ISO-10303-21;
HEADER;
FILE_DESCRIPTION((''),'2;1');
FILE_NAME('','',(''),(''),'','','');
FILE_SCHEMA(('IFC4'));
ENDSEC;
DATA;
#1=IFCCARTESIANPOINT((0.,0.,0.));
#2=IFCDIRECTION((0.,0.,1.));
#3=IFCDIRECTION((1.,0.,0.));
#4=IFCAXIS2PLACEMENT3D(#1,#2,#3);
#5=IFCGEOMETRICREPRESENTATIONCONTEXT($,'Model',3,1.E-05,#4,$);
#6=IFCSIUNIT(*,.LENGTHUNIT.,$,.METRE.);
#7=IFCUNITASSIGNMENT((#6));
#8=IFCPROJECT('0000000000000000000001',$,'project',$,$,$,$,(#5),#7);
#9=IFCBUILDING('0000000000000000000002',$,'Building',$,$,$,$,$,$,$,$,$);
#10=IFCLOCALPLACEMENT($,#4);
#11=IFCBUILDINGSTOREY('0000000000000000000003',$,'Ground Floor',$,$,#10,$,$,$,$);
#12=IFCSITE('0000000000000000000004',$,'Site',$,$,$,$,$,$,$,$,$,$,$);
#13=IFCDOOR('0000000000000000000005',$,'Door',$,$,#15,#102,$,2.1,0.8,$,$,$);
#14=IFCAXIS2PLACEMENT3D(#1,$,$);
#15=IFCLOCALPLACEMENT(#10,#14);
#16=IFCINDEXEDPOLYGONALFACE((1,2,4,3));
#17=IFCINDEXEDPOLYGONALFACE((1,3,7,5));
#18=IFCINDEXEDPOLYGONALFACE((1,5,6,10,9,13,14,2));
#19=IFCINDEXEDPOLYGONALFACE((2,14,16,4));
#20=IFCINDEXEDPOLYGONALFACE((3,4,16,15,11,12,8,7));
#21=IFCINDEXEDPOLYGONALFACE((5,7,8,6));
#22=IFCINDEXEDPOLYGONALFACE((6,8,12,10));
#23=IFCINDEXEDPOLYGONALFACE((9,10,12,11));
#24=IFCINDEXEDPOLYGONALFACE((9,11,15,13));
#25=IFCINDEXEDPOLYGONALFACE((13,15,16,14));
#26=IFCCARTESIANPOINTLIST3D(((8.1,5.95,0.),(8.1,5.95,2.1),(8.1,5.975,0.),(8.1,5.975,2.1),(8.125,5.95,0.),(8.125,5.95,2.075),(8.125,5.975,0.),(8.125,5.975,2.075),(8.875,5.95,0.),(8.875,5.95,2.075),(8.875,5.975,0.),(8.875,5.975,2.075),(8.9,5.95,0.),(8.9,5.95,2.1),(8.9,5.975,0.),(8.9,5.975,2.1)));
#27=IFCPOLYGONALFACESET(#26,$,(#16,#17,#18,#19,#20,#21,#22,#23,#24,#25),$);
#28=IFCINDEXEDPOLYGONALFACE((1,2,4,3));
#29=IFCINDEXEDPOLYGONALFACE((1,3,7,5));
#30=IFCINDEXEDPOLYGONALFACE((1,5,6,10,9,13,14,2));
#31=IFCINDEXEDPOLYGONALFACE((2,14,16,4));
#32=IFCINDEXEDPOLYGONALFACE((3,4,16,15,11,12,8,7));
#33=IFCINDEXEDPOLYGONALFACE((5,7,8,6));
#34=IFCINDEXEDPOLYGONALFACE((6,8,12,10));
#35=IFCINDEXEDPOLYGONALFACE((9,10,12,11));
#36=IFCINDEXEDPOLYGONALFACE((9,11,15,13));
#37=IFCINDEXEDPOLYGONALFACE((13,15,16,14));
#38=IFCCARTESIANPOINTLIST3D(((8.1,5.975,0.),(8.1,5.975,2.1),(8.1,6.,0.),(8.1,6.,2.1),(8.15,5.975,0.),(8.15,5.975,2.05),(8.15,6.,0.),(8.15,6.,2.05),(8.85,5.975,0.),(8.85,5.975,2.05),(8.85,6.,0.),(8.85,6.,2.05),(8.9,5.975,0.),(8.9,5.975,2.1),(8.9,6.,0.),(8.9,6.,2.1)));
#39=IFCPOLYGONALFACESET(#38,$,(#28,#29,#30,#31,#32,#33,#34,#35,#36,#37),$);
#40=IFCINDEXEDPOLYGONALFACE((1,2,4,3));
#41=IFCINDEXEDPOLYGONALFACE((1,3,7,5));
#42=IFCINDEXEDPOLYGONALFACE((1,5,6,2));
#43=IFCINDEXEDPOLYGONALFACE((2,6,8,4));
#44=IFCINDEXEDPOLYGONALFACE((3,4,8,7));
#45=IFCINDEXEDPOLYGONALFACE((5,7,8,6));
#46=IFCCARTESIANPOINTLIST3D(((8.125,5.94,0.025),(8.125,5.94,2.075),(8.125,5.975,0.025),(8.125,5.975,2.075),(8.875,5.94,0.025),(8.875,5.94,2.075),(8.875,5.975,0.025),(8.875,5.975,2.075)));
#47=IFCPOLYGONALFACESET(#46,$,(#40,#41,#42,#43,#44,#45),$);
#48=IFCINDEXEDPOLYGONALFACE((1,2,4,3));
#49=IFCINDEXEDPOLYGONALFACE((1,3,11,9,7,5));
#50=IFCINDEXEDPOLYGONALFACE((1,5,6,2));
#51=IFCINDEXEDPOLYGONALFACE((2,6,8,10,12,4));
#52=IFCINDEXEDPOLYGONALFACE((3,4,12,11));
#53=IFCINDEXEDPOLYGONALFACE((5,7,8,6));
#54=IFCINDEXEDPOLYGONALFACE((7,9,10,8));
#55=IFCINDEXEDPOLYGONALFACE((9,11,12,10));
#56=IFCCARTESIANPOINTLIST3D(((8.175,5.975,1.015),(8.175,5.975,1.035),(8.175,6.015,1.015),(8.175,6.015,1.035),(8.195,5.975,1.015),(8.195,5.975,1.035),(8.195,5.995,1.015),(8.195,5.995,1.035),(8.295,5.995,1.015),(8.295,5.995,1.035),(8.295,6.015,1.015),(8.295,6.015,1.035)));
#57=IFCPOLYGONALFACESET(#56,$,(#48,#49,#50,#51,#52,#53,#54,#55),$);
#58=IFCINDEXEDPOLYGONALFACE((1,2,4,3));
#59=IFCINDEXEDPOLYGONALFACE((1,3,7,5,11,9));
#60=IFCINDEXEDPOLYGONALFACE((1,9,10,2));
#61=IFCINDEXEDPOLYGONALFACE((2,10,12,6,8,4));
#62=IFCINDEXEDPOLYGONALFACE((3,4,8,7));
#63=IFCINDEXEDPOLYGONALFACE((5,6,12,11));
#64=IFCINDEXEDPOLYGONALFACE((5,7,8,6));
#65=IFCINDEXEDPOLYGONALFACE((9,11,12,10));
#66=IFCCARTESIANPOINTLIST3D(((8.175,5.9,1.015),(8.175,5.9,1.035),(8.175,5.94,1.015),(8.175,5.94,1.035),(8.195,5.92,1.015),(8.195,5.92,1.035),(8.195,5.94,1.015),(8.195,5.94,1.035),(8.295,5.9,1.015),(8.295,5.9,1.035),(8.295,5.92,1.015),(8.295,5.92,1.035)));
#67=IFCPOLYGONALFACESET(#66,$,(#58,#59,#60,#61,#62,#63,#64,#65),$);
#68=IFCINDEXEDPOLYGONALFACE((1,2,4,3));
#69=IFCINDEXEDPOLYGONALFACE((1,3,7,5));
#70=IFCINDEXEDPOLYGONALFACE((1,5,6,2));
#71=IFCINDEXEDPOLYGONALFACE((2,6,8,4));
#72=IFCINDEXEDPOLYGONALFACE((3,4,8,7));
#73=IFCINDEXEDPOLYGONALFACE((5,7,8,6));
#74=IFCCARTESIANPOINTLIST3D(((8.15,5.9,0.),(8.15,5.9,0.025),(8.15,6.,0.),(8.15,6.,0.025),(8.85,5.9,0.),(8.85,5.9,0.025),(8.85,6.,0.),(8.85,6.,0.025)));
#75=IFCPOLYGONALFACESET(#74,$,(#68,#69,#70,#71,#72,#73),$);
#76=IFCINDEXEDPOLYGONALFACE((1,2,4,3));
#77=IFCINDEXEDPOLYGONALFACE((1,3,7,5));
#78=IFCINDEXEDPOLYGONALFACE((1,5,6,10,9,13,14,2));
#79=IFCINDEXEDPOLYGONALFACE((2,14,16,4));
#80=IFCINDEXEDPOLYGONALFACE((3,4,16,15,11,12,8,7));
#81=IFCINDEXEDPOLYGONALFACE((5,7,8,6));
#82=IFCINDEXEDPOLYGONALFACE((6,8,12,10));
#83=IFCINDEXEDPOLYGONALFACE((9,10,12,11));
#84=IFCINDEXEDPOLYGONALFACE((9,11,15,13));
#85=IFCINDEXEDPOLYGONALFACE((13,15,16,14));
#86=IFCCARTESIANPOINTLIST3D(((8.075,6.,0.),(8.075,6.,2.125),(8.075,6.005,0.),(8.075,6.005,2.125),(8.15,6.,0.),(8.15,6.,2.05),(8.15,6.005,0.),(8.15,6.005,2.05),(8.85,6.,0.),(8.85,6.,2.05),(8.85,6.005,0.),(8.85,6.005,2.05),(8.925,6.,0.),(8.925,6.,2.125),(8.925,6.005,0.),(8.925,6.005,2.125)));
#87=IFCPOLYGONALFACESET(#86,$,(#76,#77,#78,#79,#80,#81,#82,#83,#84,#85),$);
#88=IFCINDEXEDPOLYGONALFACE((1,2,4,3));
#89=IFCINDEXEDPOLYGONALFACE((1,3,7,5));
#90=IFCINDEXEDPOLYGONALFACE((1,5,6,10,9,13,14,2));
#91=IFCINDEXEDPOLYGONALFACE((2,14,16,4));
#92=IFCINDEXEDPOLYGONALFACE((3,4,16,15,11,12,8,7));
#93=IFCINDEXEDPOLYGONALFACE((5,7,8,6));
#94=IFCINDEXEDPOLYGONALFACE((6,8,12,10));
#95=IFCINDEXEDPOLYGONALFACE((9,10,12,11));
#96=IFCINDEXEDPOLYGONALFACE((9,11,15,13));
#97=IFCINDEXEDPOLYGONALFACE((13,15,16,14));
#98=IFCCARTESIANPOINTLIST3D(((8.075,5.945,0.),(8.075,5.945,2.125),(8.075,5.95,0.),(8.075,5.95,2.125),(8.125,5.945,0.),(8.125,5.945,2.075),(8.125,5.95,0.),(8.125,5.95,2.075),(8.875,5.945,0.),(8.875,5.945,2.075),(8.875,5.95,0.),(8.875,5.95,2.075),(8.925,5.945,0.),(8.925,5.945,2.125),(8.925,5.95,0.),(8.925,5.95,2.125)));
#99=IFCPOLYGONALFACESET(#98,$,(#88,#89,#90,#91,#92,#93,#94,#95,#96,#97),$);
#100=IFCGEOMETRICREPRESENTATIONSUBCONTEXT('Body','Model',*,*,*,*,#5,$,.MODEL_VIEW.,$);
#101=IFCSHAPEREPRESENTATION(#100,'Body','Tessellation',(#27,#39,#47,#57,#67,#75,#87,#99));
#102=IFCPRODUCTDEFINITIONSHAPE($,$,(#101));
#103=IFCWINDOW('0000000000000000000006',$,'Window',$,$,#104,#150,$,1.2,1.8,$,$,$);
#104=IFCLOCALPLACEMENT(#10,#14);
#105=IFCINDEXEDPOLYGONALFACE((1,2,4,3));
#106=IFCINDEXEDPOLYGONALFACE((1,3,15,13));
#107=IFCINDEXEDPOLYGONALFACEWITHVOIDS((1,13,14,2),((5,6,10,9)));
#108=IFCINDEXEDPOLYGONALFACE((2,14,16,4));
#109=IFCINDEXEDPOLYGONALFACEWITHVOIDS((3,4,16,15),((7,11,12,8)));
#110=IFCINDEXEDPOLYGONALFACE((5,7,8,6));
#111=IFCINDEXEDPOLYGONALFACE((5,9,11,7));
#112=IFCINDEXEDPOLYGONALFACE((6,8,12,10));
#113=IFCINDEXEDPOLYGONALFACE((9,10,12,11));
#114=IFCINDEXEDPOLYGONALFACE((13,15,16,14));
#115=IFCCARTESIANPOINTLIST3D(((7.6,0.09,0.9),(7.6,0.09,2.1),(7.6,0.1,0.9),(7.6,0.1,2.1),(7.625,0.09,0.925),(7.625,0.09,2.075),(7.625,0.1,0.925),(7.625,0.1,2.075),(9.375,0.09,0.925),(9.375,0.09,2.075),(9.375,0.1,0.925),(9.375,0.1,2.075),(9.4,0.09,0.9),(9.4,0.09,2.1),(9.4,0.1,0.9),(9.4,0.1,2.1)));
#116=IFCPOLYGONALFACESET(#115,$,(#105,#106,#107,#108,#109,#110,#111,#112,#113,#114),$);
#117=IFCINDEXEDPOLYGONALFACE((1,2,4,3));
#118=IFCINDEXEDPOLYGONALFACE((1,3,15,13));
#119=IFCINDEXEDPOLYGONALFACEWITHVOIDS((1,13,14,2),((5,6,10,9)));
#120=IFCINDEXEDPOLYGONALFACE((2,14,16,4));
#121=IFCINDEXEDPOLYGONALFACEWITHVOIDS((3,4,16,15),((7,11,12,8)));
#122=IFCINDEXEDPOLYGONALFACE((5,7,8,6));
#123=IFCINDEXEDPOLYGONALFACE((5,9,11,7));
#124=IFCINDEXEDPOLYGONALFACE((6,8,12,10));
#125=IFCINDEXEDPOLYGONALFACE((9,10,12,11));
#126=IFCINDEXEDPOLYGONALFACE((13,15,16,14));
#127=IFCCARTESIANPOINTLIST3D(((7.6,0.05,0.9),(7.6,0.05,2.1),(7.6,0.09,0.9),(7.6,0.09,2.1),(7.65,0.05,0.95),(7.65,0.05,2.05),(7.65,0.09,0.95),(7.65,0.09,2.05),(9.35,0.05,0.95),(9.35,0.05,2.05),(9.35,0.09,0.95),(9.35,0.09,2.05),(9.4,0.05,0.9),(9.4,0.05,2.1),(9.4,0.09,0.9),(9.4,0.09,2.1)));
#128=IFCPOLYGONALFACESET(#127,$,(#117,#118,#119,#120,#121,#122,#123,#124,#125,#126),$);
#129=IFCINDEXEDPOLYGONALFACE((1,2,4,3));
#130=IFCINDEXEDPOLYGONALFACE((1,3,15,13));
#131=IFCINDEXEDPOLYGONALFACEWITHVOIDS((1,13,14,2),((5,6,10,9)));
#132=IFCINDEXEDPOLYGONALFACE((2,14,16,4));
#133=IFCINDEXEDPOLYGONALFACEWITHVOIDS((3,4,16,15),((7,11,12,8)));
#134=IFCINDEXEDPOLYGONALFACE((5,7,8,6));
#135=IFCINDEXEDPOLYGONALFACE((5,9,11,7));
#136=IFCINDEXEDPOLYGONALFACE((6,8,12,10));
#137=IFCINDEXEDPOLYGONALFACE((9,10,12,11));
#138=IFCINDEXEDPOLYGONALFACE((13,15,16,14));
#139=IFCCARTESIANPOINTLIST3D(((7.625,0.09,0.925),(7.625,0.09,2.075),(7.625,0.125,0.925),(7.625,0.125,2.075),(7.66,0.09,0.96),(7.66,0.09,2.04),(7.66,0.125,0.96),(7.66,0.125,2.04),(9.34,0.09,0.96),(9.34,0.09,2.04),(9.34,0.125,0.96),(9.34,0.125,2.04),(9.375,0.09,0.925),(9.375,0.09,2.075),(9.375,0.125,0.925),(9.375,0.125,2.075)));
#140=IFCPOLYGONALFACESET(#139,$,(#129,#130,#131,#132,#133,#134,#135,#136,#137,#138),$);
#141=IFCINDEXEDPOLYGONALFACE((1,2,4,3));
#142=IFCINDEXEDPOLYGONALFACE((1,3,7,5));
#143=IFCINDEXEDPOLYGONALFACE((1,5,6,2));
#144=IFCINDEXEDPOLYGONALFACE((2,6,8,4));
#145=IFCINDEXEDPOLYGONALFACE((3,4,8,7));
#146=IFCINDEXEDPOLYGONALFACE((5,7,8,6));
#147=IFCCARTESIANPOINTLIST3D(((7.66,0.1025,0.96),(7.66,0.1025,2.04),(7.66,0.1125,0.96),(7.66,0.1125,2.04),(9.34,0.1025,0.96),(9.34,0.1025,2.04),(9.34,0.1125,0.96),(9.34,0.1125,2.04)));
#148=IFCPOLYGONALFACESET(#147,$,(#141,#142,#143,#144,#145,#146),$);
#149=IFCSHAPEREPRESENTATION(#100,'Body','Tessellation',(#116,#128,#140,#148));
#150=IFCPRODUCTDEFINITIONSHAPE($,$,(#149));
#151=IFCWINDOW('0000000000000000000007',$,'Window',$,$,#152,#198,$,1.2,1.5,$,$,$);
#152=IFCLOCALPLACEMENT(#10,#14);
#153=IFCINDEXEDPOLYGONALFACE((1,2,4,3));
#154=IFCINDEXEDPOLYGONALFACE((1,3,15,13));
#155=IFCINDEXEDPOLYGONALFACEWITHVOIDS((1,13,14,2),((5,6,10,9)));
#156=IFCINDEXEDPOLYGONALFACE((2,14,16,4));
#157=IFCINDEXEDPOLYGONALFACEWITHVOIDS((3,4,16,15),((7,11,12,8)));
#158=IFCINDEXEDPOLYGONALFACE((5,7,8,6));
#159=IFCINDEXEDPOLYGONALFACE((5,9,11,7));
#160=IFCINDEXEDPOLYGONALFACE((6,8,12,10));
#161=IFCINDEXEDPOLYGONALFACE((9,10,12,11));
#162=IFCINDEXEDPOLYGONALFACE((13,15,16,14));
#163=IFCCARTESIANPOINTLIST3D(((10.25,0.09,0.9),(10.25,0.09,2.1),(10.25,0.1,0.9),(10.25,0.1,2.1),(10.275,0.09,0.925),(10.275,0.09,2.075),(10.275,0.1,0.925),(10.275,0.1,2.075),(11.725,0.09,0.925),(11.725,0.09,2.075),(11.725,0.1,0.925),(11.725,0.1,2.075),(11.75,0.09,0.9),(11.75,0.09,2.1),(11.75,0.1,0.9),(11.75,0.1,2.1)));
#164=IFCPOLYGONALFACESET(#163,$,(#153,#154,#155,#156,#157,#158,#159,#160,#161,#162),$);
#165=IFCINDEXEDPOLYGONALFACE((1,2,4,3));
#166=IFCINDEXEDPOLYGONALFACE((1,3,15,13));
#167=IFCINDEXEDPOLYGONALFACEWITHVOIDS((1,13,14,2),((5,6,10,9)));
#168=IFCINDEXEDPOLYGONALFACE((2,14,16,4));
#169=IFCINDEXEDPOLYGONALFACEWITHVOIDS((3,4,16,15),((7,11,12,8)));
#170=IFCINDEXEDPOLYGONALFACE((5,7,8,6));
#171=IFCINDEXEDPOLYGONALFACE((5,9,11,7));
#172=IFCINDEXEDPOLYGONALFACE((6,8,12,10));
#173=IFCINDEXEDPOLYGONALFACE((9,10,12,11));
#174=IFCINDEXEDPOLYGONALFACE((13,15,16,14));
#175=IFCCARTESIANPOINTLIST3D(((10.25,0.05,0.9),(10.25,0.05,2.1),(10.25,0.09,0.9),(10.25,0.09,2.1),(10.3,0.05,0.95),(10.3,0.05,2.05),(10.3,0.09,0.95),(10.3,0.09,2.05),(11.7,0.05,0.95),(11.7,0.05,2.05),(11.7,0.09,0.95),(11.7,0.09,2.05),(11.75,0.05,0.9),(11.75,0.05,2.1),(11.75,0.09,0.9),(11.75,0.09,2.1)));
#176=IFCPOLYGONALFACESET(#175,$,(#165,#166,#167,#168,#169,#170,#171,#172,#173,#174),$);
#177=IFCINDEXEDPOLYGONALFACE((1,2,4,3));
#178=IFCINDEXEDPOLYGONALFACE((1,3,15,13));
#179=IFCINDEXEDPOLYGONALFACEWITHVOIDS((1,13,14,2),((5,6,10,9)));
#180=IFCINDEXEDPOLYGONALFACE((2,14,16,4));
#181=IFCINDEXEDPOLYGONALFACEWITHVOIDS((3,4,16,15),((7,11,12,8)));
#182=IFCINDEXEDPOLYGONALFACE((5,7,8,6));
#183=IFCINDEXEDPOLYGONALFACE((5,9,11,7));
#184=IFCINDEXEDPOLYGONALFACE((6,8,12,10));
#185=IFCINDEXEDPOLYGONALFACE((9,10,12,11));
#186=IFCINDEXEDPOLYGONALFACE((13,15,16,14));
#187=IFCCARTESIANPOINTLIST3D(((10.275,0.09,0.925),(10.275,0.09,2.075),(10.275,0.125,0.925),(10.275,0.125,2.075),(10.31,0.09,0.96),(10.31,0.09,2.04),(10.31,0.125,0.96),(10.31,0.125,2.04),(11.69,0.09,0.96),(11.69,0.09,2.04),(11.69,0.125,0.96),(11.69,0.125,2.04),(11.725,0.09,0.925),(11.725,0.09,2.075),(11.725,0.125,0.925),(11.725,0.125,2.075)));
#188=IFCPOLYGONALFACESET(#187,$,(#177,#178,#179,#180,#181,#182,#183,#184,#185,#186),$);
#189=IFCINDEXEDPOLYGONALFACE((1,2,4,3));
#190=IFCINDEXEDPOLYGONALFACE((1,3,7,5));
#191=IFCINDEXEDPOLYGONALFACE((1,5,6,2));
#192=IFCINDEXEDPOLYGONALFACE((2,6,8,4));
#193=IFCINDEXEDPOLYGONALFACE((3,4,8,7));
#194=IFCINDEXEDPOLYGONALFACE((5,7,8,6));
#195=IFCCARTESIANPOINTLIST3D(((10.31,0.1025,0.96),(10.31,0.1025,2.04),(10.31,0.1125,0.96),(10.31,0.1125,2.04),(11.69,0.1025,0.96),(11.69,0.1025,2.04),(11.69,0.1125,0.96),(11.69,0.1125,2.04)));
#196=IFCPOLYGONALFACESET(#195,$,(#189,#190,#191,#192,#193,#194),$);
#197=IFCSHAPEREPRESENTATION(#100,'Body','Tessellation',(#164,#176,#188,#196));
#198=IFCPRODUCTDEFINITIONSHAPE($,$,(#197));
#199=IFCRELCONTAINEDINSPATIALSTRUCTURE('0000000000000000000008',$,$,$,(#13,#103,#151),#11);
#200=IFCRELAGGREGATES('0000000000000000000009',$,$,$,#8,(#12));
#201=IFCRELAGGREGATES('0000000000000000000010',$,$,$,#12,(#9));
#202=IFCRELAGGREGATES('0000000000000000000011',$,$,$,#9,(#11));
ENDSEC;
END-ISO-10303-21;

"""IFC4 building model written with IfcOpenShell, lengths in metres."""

from ifc_helpers import new_model, si_unit, frame, origin_with_axes, place, context, subcontext, project, spatial, line, indexed_curve, outline, extrude, element, save


model = new_model("IFC4")

# Units and contexts
model_context = context("Model", 3, precision=1e-05, world=origin_with_axes())
body_context = subcontext(model_context, "Body", "Model", "MODEL_VIEW")
ifc_project = project(units=[si_unit("LENGTHUNIT", "METRE")], contexts=[model_context])

# Site, building, storey
site = spatial("IfcSite", under=ifc_project, Name="Site")
building = spatial("IfcBuilding", under=site, Name="Building")
storey_placement = place(None, origin_with_axes())
storey = spatial("IfcBuildingStorey", under=building, at=storey_placement, Name="Ground Floor")

# Door
door_1_placement = place(storey_placement, frame((8.9, 6.0, 0.0), z_axis=(0.0, 0.0, 1.0), x_axis=(-1.0, 0.0, 0.0)))
element("IfcDoor", 1, at=door_1_placement, inside=storey, Name="Door", OverallHeight=2.1, OverallWidth=0.8, context=body_context, shape_type="SweptSolid", body=[
    extrude(outline(indexed_curve([(0.0, 0.0), (0.0, 2.1), (0.8, 2.1), (0.8, 0.0), (0.775, 0.0), (0.775, 2.075), (0.025, 2.075), (0.025, 0.0)], segments=[line(1, 2, 3, 4, 5, 6, 7, 8, 1)])), frame((0.0, 0.025, 0.0), z_axis=(0.0, -1.0, 0.0), x_axis=(1.0, 0.0, 0.0)), (0.0, 0.0, -1.0), 0.025),
    extrude(outline(indexed_curve([(0.0, 0.0), (0.0, 2.1), (0.8, 2.1), (0.8, 0.0), (0.75, 0.0), (0.75, 2.05), (0.05, 2.05), (0.05, 0.0)], segments=[line(1, 2, 3, 4, 5, 6, 7, 8, 1)])), frame((0.0, 0.0, 0.0), z_axis=(0.0, -1.0, 0.0), x_axis=(1.0, 0.0, 0.0)), (0.0, 0.0, -1.0), 0.025),
    extrude(outline(indexed_curve([(0.0, 0.0), (0.75, 0.0), (0.75, 0.035), (0.0, 0.035)], segments=[line(1, 2, 3, 4, 1)])), frame((0.025, 0.025, 0.025), z_axis=(0.0, 0.0, 1.0), x_axis=(1.0, 0.0, 0.0)), (0.0, 0.0, 1.0), 2.05),
    extrude(outline(indexed_curve([(0.0, 0.0), (0.0, -0.04), (-0.12, -0.04), (-0.12, -0.02), (-0.02, -0.02), (-0.02, 0.0)], segments=[line(1, 2, 3, 4, 5, 6, 1)])), frame((0.725, 0.025, 1.015), z_axis=(0.0, 0.0, 1.0), x_axis=(1.0, 0.0, 0.0)), (0.0, 0.0, 1.0), 0.02),
    extrude(outline(indexed_curve([(0.0, 0.0), (0.0, 0.04), (-0.12, 0.04), (-0.12, 0.02), (-0.02, 0.02), (-0.02, 0.0)], segments=[line(1, 2, 3, 4, 5, 6, 1)])), frame((0.725, 0.06, 1.015), z_axis=(0.0, 0.0, 1.0), x_axis=(1.0, 0.0, 0.0)), (0.0, 0.0, 1.0), 0.02),
    extrude(outline(indexed_curve([(0.0, 0.0), (0.7, 0.0), (0.7, 0.1), (0.0, 0.1)], segments=[line(1, 2, 3, 4, 1)])), frame((0.05, 0.0, 0.0), z_axis=(0.0, 0.0, 1.0), x_axis=(1.0, 0.0, 0.0)), (0.0, 0.0, 1.0), 0.025),
    extrude(outline(indexed_curve([(0.0, 0.0), (0.0, 2.125), (0.85, 2.125), (0.85, 0.0), (0.775, 0.0), (0.775, 2.05), (0.075, 2.05), (0.075, 0.0)], segments=[line(1, 2, 3, 4, 5, 6, 7, 8, 1)])), frame((-0.025, -0.005, 0.0), z_axis=(0.0, -1.0, 0.0), x_axis=(1.0, 0.0, 0.0)), (0.0, 0.0, -1.0), 0.005),
    extrude(outline(indexed_curve([(0.0, 0.0), (0.0, 2.125), (0.85, 2.125), (0.85, 0.0), (0.8, 0.0), (0.8, 2.075), (0.05, 2.075), (0.05, 0.0)], segments=[line(1, 2, 3, 4, 5, 6, 7, 8, 1)])), frame((-0.025, 0.05, 0.0), z_axis=(0.0, -1.0, 0.0), x_axis=(1.0, 0.0, 0.0)), (0.0, 0.0, -1.0), 0.005),
])

# Windows
window_1_placement = place(storey_placement, frame((7.6, 0.0, 0.9), z_axis=(0.0, 0.0, 1.0), x_axis=(1.0, 0.0, 0.0)))
element("IfcWindow", 2, at=window_1_placement, inside=storey, Name="Window", OverallHeight=1.2, OverallWidth=1.8, context=body_context, shape_type="SweptSolid", body=[
    extrude(outline(indexed_curve([(0.0, 0.0), (1.8, 0.0), (1.8, 1.2), (0.0, 1.2)], segments=[line(1, 2, 3, 4, 1)]), holes=[indexed_curve([(0.025, 0.025), (1.775, 0.025), (1.775, 1.175), (0.025, 1.175)], segments=[line(1, 2, 3, 4, 1)])]), frame((0.0, 0.09, 0.0), z_axis=(0.0, -1.0, 0.0), x_axis=(1.0, 0.0, 0.0)), (0.0, 0.0, -1.0), 0.01),
    extrude(outline(indexed_curve([(0.0, 0.0), (1.8, 0.0), (1.8, 1.2), (0.0, 1.2)], segments=[line(1, 2, 3, 4, 1)]), holes=[indexed_curve([(0.05, 0.05), (1.75, 0.05), (1.75, 1.15), (0.05, 1.15)], segments=[line(1, 2, 3, 4, 1)])]), frame((0.0, 0.05, 0.0), z_axis=(0.0, -1.0, 0.0), x_axis=(1.0, 0.0, 0.0)), (0.0, 0.0, -1.0), 0.04),
    extrude(outline(indexed_curve([(0.0, 0.0), (1.75, 0.0), (1.75, 1.15), (0.0, 1.15)], segments=[line(1, 2, 3, 4, 1)]), holes=[indexed_curve([(0.035, 0.035), (1.715, 0.035), (1.715, 1.115), (0.035, 1.115)], segments=[line(1, 2, 3, 4, 1)])]), frame((0.025, 0.09, 0.025), z_axis=(0.0, -1.0, 0.0), x_axis=(1.0, 0.0, 0.0)), (0.0, 0.0, -1.0), 0.035),
    extrude(outline(indexed_curve([(0.035, 0.035), (1.715, 0.035), (1.715, 1.115), (0.035, 1.115)], segments=[line(1, 2, 3, 4, 1)])), frame((0.025, 0.1025, 0.025), z_axis=(0.0, -1.0, 0.0), x_axis=(1.0, 0.0, 0.0)), (0.0, 0.0, -1.0), 0.01),
])
window_2_placement = place(storey_placement, frame((10.25, 0.0, 0.9), z_axis=(0.0, 0.0, 1.0), x_axis=(1.0, 0.0, 0.0)))
element("IfcWindow", 3, at=window_2_placement, inside=storey, Name="Window", OverallHeight=1.2, OverallWidth=1.5, context=body_context, shape_type="SweptSolid", body=[
    extrude(outline(indexed_curve([(0.0, 0.0), (1.5, 0.0), (1.5, 1.2), (0.0, 1.2)], segments=[line(1, 2, 3, 4, 1)]), holes=[indexed_curve([(0.025, 0.025), (1.475, 0.025), (1.475, 1.175), (0.025, 1.175)], segments=[line(1, 2, 3, 4, 1)])]), frame((0.0, 0.09, 0.0), z_axis=(0.0, -1.0, 0.0), x_axis=(1.0, 0.0, 0.0)), (0.0, 0.0, -1.0), 0.01),
    extrude(outline(indexed_curve([(0.0, 0.0), (1.5, 0.0), (1.5, 1.2), (0.0, 1.2)], segments=[line(1, 2, 3, 4, 1)]), holes=[indexed_curve([(0.05, 0.05), (1.45, 0.05), (1.45, 1.15), (0.05, 1.15)], segments=[line(1, 2, 3, 4, 1)])]), frame((0.0, 0.05, 0.0), z_axis=(0.0, -1.0, 0.0), x_axis=(1.0, 0.0, 0.0)), (0.0, 0.0, -1.0), 0.04),
    extrude(outline(indexed_curve([(0.0, 0.0), (1.45, 0.0), (1.45, 1.15), (0.0, 1.15)], segments=[line(1, 2, 3, 4, 1)]), holes=[indexed_curve([(0.035, 0.035), (1.415, 0.035), (1.415, 1.115), (0.035, 1.115)], segments=[line(1, 2, 3, 4, 1)])]), frame((0.025, 0.09, 0.025), z_axis=(0.0, -1.0, 0.0), x_axis=(1.0, 0.0, 0.0)), (0.0, 0.0, -1.0), 0.035),
    extrude(outline(indexed_curve([(0.035, 0.035), (1.415, 0.035), (1.415, 1.115), (0.035, 1.115)], segments=[line(1, 2, 3, 4, 1)])), frame((0.025, 0.1025, 0.025), z_axis=(0.0, -1.0, 0.0), x_axis=(1.0, 0.0, 0.0)), (0.0, 0.0, -1.0), 0.01),
])

save(model, "model.ifc")
